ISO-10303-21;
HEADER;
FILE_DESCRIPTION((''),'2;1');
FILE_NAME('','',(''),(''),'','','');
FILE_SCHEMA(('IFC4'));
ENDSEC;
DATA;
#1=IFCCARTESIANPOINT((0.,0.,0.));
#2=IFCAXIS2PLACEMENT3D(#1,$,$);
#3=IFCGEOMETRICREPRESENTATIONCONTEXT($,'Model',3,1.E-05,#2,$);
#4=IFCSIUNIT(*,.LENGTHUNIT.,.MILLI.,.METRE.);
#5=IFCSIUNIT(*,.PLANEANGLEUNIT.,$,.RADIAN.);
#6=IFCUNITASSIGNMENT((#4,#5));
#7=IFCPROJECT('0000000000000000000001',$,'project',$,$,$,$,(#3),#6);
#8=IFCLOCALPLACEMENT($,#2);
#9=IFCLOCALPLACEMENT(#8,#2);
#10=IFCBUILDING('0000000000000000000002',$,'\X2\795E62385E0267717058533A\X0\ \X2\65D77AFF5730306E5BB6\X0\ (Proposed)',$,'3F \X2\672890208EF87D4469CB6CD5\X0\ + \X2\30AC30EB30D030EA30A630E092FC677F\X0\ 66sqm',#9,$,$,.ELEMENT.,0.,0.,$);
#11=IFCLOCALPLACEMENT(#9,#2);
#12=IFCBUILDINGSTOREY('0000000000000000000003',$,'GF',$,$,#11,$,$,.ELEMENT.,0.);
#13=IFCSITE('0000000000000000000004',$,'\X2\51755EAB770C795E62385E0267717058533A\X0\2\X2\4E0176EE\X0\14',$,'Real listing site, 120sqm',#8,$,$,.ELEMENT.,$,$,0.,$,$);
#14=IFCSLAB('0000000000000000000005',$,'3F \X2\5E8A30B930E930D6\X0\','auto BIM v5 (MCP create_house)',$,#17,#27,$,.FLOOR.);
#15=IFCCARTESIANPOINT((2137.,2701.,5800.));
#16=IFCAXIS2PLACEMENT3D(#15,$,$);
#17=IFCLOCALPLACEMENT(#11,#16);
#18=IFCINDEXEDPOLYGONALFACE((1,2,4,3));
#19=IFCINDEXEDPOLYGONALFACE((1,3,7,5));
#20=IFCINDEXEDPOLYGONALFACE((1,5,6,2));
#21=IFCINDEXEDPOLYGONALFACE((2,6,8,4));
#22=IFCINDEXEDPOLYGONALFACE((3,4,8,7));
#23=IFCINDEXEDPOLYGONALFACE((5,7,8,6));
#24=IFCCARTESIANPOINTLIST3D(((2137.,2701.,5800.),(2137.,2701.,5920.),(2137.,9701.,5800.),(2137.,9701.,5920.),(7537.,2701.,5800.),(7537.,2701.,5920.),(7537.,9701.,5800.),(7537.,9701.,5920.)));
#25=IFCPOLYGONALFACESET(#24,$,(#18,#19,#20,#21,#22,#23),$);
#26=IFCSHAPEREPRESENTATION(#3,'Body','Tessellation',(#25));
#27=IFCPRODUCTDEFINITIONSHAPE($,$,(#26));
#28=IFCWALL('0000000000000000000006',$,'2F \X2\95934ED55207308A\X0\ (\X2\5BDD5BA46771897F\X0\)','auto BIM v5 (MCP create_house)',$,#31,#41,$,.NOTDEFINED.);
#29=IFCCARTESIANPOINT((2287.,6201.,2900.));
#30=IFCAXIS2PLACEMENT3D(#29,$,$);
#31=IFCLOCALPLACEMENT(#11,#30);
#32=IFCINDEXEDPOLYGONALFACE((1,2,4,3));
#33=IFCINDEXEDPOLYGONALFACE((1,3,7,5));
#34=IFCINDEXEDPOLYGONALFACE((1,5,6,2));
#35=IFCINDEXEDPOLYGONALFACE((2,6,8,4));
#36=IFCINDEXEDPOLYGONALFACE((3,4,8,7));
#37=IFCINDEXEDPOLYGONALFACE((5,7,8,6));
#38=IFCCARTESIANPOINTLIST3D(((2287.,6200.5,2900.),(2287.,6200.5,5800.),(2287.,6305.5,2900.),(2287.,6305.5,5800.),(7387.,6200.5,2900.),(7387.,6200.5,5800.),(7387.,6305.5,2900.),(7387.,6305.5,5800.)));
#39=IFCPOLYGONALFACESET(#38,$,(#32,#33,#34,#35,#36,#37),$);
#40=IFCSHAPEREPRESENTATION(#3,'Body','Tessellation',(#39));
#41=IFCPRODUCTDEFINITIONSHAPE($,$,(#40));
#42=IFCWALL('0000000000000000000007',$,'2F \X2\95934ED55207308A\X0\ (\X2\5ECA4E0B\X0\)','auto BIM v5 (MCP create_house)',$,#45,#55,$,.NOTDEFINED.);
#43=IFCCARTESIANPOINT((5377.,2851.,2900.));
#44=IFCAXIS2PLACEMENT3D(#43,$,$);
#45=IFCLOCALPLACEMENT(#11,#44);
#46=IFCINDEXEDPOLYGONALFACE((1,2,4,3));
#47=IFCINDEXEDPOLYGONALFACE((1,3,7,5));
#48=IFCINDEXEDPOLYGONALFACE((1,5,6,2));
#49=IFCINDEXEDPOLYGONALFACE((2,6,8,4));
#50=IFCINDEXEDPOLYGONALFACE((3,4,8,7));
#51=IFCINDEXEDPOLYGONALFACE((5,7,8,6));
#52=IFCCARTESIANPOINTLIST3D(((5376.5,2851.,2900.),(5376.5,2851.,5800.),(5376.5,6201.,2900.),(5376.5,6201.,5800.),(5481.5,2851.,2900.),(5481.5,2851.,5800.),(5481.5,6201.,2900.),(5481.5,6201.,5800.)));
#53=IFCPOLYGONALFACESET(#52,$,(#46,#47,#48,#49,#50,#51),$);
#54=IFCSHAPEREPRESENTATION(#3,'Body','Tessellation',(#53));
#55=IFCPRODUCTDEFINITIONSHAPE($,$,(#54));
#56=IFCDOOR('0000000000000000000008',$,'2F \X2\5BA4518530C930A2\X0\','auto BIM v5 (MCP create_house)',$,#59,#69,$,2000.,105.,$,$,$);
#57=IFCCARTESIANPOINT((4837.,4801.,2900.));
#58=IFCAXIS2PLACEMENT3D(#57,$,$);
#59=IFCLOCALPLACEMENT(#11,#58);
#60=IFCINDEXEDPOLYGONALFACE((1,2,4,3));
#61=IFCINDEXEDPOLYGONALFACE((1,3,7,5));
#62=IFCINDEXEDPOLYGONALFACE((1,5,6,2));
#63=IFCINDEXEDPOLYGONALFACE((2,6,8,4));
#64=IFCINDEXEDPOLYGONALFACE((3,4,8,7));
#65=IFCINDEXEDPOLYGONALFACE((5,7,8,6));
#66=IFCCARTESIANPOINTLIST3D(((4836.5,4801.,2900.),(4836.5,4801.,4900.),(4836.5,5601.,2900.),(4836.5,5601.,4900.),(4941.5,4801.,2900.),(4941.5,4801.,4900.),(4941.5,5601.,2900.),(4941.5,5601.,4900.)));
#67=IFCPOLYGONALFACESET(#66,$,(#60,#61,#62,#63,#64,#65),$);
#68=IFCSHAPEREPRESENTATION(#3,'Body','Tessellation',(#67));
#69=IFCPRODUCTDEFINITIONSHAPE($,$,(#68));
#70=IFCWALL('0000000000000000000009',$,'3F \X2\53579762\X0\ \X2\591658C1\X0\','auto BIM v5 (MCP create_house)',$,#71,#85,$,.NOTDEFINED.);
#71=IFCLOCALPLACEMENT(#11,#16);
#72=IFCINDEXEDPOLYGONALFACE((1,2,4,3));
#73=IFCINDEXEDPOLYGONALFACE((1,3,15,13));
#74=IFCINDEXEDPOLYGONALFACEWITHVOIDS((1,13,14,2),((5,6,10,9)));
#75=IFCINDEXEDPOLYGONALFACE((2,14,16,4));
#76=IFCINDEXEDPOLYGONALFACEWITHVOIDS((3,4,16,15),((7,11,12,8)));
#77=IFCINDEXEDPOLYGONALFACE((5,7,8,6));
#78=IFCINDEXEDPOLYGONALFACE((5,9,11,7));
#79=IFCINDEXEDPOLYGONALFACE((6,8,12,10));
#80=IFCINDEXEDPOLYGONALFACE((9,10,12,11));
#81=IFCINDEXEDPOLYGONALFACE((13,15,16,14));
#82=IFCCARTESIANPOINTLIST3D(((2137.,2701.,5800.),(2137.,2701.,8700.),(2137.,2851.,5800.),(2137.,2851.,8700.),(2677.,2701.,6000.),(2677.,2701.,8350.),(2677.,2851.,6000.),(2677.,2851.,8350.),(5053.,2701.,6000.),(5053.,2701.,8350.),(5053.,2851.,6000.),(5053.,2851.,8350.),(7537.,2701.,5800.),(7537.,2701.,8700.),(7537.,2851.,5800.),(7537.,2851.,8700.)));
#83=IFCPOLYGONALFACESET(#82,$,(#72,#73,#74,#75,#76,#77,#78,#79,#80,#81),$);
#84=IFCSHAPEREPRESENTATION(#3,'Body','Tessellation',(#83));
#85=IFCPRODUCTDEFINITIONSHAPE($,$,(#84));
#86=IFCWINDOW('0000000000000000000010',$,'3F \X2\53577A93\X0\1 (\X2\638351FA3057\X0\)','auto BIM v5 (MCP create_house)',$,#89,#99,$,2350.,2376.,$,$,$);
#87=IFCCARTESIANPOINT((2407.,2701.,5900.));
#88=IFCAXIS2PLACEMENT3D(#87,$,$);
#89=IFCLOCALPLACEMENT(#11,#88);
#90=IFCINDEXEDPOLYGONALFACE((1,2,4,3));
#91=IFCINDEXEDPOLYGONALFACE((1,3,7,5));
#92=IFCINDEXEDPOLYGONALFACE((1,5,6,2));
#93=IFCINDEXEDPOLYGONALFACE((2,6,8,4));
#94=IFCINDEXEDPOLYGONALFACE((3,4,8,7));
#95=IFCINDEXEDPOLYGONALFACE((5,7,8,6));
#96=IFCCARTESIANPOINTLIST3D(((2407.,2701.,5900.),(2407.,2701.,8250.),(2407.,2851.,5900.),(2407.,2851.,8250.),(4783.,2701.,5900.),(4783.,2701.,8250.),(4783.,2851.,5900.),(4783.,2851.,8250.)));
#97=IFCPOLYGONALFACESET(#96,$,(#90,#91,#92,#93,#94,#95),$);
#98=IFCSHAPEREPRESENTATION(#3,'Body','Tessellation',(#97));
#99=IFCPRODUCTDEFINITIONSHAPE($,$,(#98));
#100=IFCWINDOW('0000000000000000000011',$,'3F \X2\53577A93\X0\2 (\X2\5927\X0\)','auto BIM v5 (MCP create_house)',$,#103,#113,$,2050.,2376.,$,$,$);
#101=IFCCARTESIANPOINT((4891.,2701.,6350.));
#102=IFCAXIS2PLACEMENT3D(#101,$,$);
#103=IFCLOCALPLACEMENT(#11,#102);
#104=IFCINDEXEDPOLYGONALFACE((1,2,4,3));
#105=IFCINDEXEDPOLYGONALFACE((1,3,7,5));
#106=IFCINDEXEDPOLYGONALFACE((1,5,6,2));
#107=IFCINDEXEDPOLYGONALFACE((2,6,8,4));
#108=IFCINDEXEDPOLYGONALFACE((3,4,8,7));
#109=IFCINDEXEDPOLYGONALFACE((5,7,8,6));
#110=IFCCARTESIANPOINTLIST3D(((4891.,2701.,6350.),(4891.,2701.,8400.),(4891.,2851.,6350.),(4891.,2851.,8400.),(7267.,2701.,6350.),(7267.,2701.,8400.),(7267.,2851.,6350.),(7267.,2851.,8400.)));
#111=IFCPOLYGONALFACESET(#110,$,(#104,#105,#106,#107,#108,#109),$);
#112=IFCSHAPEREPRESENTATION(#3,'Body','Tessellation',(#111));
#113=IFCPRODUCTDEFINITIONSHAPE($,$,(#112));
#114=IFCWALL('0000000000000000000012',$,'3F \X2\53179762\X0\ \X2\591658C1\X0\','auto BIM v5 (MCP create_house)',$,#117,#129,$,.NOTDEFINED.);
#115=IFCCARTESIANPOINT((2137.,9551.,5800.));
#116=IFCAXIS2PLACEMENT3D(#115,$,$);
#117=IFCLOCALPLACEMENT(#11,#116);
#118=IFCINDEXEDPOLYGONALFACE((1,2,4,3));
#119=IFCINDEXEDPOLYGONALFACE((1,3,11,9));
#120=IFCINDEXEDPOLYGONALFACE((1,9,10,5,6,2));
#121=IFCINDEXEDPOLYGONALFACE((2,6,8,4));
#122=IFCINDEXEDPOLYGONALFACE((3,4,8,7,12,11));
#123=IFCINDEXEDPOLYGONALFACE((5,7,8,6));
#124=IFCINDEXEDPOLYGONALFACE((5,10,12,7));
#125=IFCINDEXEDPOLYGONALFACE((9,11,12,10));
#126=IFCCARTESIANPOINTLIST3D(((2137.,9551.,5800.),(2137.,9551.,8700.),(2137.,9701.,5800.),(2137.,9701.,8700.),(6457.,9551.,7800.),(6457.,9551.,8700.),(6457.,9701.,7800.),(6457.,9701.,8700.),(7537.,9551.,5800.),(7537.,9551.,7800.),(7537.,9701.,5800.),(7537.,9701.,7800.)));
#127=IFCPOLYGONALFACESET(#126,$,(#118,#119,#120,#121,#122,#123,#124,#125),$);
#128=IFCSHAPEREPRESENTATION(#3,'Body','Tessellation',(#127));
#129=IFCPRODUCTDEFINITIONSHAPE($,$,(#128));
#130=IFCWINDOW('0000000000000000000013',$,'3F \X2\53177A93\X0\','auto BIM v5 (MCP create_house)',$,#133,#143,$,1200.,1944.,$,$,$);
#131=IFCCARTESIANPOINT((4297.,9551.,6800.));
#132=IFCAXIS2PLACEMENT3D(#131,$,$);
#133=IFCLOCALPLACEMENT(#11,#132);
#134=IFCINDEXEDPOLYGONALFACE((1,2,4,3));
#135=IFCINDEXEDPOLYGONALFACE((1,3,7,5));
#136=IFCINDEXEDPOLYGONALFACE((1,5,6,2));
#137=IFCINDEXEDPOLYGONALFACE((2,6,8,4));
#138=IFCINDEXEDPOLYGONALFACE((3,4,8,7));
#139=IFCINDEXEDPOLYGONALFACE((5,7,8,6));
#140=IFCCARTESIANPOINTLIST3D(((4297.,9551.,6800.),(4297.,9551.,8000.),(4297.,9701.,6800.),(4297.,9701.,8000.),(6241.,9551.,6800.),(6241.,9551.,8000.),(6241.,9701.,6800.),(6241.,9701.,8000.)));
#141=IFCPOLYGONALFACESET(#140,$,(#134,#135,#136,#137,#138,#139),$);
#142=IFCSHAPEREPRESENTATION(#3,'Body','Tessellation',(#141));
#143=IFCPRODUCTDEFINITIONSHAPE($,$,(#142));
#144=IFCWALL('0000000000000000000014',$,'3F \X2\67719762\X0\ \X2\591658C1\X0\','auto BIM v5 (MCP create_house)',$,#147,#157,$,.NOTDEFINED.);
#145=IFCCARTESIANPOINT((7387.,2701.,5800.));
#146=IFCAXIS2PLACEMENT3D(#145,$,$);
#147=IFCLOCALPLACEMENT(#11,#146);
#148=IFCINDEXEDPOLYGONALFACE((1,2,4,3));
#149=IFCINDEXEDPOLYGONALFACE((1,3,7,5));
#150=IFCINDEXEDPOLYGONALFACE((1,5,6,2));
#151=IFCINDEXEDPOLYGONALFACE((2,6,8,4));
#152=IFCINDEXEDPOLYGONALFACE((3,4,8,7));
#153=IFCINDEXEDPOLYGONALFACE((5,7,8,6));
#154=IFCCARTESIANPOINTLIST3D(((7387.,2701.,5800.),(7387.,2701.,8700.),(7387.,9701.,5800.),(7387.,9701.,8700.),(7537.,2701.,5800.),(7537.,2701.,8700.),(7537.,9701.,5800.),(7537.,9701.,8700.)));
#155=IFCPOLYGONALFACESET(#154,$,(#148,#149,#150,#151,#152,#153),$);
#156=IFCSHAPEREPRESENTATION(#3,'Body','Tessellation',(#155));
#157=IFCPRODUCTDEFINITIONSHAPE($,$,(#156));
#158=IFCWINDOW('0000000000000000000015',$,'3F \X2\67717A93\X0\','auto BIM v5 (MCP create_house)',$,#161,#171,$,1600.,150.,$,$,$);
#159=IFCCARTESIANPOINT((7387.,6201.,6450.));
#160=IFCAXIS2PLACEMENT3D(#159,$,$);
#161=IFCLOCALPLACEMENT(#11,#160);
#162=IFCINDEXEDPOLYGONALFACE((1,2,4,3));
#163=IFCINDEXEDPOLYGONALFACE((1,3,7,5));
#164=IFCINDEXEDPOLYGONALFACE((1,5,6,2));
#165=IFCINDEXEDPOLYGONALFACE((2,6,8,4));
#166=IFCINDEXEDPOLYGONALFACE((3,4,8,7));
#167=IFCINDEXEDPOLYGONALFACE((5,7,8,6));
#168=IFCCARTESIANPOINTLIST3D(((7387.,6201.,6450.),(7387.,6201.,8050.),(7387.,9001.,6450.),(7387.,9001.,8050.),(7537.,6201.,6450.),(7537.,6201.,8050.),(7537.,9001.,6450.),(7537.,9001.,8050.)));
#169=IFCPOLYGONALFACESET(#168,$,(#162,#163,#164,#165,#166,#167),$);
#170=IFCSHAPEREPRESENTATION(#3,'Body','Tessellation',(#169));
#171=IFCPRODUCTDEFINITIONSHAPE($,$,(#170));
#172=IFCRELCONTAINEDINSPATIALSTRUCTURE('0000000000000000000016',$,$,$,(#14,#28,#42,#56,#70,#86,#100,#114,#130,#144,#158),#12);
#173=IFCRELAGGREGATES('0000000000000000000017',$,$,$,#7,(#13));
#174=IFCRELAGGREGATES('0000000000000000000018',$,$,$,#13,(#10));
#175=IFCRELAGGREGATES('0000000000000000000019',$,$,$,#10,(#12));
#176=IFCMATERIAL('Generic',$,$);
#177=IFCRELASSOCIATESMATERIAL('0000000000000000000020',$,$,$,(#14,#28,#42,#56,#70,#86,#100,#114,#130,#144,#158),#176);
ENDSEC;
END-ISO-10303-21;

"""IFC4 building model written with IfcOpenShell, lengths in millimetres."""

from ifc_helpers import new_model, si_unit, frame, frame_2d, origin, place, context, project, spatial, rectangle, extrude, material, element, fill, save


model = new_model("IFC4")

# Units and contexts
model_context = context("Model", 3, precision=1e-05, world=origin())
ifc_project = project(units=[si_unit("LENGTHUNIT", "METRE", prefix="MILLI"), si_unit("PLANEANGLEUNIT", "RADIAN")], contexts=[model_context])

# Site, building, storey
site_placement = place(None, origin())
site = spatial("IfcSite", under=ifc_project, at=site_placement, Name="兵庫県神戸市東灘区2丁目14", ObjectType="Real listing site, 120sqm", CompositionType="ELEMENT", RefElevation=0.0)
building_placement = place(site_placement, origin())
building = spatial("IfcBuilding", under=site, at=building_placement, Name="神戸市東灘区 旗竿地の家 (Proposed)", ObjectType="3F 木造軸組構法 + ガルバリウム鋼板 66sqm", CompositionType="ELEMENT", ElevationOfRefHeight=0.0, ElevationOfTerrain=0.0)
storey_placement = place(building_placement, origin())
storey = spatial("IfcBuildingStorey", under=building, at=storey_placement, Name="GF", CompositionType="ELEMENT", Elevation=0.0)

# Slab
ifc_material = material(Name="Generic")
slab_placement = place(storey_placement, frame((2137.0, 2701.0, 5800.0)))
element("IfcSlab", 1, at=slab_placement, inside=storey, material=ifc_material, Name="3F 床スラブ", Description="auto BIM v5 (MCP create_house)", PredefinedType="FLOOR", context=model_context, shape_type="SweptSolid", body=[
    extrude(rectangle(XDim=5400.0, YDim=7000.0, at=frame_2d((2700.0, 3500.0))), frame((2137.0, 2701.0, 5800.0)), (0.0, 0.0, 1.0), 120.0),
])

# Walls
wall_1_placement = place(storey_placement, frame((2287.0, 6201.0, 2900.0)))
element("IfcWall", 2, at=wall_1_placement, inside=storey, material=ifc_material, Name="2F 間仕切り (寝室東西)", Description="auto BIM v5 (MCP create_house)", PredefinedType="NOTDEFINED", context=model_context, shape_type="SweptSolid", body=[
    extrude(rectangle(XDim=5100.0, YDim=105.0, at=frame_2d((2550.0, 52.0))), frame((2287.0, 6201.0, 2900.0)), (0.0, 0.0, 1.0), 2900.0),
])
wall_2_placement = place(storey_placement, frame((5377.0, 2851.0, 2900.0)))
element("IfcWall", 3, at=wall_2_placement, inside=storey, material=ifc_material, Name="2F 間仕切り (廊下)", Description="auto BIM v5 (MCP create_house)", PredefinedType="NOTDEFINED", context=model_context, shape_type="SweptSolid", body=[
    extrude(rectangle(XDim=105.0, YDim=3350.0, at=frame_2d((52.0, 1675.0))), frame((5377.0, 2851.0, 2900.0)), (0.0, 0.0, 1.0), 2900.0),
])

# Door
door_1_placement = place(storey_placement, frame((4837.0, 4801.0, 2900.0)))
element("IfcDoor", 4, at=door_1_placement, inside=storey, material=ifc_material, Name="2F 室内ドア", Description="auto BIM v5 (MCP create_house)", OverallHeight=2000.0, OverallWidth=105.0, context=model_context, shape_type="SweptSolid", body=[
    extrude(rectangle(XDim=105.0, YDim=800.0, at=frame_2d((52.0, 400.0))), frame((4837.0, 4801.0, 2900.0)), (0.0, 0.0, 1.0), 2000.0),
])

# Wall, openings, windows
wall_3_placement = place(storey_placement, frame((2137.0, 2701.0, 5800.0)))
wall_3 = element("IfcWall", 5, at=wall_3_placement, inside=storey, material=ifc_material, Name="3F 南面 外壁", Description="auto BIM v5 (MCP create_house)", PredefinedType="NOTDEFINED", context=model_context, shape_type="SweptSolid", body=[
    extrude(rectangle(XDim=5400.0, YDim=150.0, at=frame_2d((2700.0, 75.0))), frame((2137.0, 2701.0, 5800.0)), (0.0, 0.0, 1.0), 2900.0),
])
opening_1_placement = place(storey_placement, frame((2407.0, 2701.0, 5900.0)))
opening_1 = element("IfcOpeningElement", 6, at=opening_1_placement, cuts=wall_3, PredefinedType="NOTDEFINED", context=model_context, shape_type="SweptSolid", body=[
    extrude(rectangle(XDim=2376.0, YDim=150.0, at=frame_2d((1188.0, 75.0))), frame((2407.0, 2701.0, 5900.0)), (0.0, 0.0, 1.0), 2350.0),
])
opening_2_placement = place(storey_placement, frame((4891.0, 2701.0, 6350.0)))
opening_2 = element("IfcOpeningElement", 7, at=opening_2_placement, cuts=wall_3, PredefinedType="NOTDEFINED", context=model_context, shape_type="SweptSolid", body=[
    extrude(rectangle(XDim=2376.0, YDim=150.0, at=frame_2d((1188.0, 75.0))), frame((4891.0, 2701.0, 6350.0)), (0.0, 0.0, 1.0), 2050.0),
])
window_1_placement = place(storey_placement, frame((2407.0, 2701.0, 5900.0)))
window_1 = element("IfcWindow", 8, at=window_1_placement, inside=storey, material=ifc_material, Name="3F 南窓1 (掃出し)", Description="auto BIM v5 (MCP create_house)", OverallHeight=2350.0, OverallWidth=2376.0, context=model_context, shape_type="SweptSolid", body=[
    extrude(rectangle(XDim=2376.0, YDim=150.0, at=frame_2d((1188.0, 75.0))), frame((2407.0, 2701.0, 5900.0)), (0.0, 0.0, 1.0), 2350.0),
])
fill(opening_1, window_1)
window_2_placement = place(storey_placement, frame((4891.0, 2701.0, 6350.0)))
window_2 = element("IfcWindow", 9, at=window_2_placement, inside=storey, material=ifc_material, Name="3F 南窓2 (大)", Description="auto BIM v5 (MCP create_house)", OverallHeight=2050.0, OverallWidth=2376.0, context=model_context, shape_type="SweptSolid", body=[
    extrude(rectangle(XDim=2376.0, YDim=150.0, at=frame_2d((1188.0, 75.0))), frame((4891.0, 2701.0, 6350.0)), (0.0, 0.0, 1.0), 2050.0),
])
fill(opening_2, window_2)

# Walls, openings, windows
wall_4_placement = place(storey_placement, frame((2137.0, 9551.0, 5800.0)))
wall_4 = element("IfcWall", 10, at=wall_4_placement, inside=storey, material=ifc_material, Name="3F 北面 外壁", Description="auto BIM v5 (MCP create_house)", PredefinedType="NOTDEFINED", context=model_context, shape_type="SweptSolid", body=[
    extrude(rectangle(XDim=5400.0, YDim=150.0, at=frame_2d((2700.0, 75.0))), frame((2137.0, 9551.0, 5800.0)), (0.0, 0.0, 1.0), 2900.0),
])
opening_3_placement = place(storey_placement, frame((4297.0, 9551.0, 6800.0)))
opening_3 = element("IfcOpeningElement", 11, at=opening_3_placement, cuts=wall_4, PredefinedType="NOTDEFINED", context=model_context, shape_type="SweptSolid", body=[
    extrude(rectangle(XDim=1944.0, YDim=150.0, at=frame_2d((972.0, 75.0))), frame((4297.0, 9551.0, 6800.0)), (0.0, 0.0, 1.0), 1200.0),
])
window_3_placement = place(storey_placement, frame((4297.0, 9551.0, 6800.0)))
window_3 = element("IfcWindow", 12, at=window_3_placement, inside=storey, material=ifc_material, Name="3F 北窓", Description="auto BIM v5 (MCP create_house)", OverallHeight=1200.0, OverallWidth=1944.0, context=model_context, shape_type="SweptSolid", body=[
    extrude(rectangle(XDim=1944.0, YDim=150.0, at=frame_2d((972.0, 75.0))), frame((4297.0, 9551.0, 6800.0)), (0.0, 0.0, 1.0), 1200.0),
])
fill(opening_3, window_3)
wall_5_placement = place(storey_placement, frame((7387.0, 2701.0, 5800.0)))
wall_5 = element("IfcWall", 13, at=wall_5_placement, inside=storey, material=ifc_material, Name="3F 東面 外壁", Description="auto BIM v5 (MCP create_house)", PredefinedType="NOTDEFINED", context=model_context, shape_type="SweptSolid", body=[
    extrude(rectangle(XDim=150.0, YDim=7000.0, at=frame_2d((75.0, 3500.0))), frame((7387.0, 2701.0, 5800.0)), (0.0, 0.0, 1.0), 2900.0),
])
opening_4_placement = place(storey_placement, frame((7387.0, 6201.0, 6450.0)))
opening_4 = element("IfcOpeningElement", 14, at=opening_4_placement, cuts=wall_5, PredefinedType="NOTDEFINED", context=model_context, shape_type="SweptSolid", body=[
    extrude(rectangle(XDim=150.0, YDim=2800.0, at=frame_2d((75.0, 1400.0))), frame((7387.0, 6201.0, 6450.0)), (0.0, 0.0, 1.0), 1600.0),
])
window_4_placement = place(storey_placement, frame((7387.0, 6201.0, 6450.0)))
window_4 = element("IfcWindow", 15, at=window_4_placement, inside=storey, material=ifc_material, Name="3F 東窓", Description="auto BIM v5 (MCP create_house)", OverallHeight=1600.0, OverallWidth=150.0, context=model_context, shape_type="SweptSolid", body=[
    extrude(rectangle(XDim=150.0, YDim=2800.0, at=frame_2d((75.0, 1400.0))), frame((7387.0, 6201.0, 6450.0)), (0.0, 0.0, 1.0), 1600.0),
])
fill(opening_4, window_4)

save(model, "model.ifc")
